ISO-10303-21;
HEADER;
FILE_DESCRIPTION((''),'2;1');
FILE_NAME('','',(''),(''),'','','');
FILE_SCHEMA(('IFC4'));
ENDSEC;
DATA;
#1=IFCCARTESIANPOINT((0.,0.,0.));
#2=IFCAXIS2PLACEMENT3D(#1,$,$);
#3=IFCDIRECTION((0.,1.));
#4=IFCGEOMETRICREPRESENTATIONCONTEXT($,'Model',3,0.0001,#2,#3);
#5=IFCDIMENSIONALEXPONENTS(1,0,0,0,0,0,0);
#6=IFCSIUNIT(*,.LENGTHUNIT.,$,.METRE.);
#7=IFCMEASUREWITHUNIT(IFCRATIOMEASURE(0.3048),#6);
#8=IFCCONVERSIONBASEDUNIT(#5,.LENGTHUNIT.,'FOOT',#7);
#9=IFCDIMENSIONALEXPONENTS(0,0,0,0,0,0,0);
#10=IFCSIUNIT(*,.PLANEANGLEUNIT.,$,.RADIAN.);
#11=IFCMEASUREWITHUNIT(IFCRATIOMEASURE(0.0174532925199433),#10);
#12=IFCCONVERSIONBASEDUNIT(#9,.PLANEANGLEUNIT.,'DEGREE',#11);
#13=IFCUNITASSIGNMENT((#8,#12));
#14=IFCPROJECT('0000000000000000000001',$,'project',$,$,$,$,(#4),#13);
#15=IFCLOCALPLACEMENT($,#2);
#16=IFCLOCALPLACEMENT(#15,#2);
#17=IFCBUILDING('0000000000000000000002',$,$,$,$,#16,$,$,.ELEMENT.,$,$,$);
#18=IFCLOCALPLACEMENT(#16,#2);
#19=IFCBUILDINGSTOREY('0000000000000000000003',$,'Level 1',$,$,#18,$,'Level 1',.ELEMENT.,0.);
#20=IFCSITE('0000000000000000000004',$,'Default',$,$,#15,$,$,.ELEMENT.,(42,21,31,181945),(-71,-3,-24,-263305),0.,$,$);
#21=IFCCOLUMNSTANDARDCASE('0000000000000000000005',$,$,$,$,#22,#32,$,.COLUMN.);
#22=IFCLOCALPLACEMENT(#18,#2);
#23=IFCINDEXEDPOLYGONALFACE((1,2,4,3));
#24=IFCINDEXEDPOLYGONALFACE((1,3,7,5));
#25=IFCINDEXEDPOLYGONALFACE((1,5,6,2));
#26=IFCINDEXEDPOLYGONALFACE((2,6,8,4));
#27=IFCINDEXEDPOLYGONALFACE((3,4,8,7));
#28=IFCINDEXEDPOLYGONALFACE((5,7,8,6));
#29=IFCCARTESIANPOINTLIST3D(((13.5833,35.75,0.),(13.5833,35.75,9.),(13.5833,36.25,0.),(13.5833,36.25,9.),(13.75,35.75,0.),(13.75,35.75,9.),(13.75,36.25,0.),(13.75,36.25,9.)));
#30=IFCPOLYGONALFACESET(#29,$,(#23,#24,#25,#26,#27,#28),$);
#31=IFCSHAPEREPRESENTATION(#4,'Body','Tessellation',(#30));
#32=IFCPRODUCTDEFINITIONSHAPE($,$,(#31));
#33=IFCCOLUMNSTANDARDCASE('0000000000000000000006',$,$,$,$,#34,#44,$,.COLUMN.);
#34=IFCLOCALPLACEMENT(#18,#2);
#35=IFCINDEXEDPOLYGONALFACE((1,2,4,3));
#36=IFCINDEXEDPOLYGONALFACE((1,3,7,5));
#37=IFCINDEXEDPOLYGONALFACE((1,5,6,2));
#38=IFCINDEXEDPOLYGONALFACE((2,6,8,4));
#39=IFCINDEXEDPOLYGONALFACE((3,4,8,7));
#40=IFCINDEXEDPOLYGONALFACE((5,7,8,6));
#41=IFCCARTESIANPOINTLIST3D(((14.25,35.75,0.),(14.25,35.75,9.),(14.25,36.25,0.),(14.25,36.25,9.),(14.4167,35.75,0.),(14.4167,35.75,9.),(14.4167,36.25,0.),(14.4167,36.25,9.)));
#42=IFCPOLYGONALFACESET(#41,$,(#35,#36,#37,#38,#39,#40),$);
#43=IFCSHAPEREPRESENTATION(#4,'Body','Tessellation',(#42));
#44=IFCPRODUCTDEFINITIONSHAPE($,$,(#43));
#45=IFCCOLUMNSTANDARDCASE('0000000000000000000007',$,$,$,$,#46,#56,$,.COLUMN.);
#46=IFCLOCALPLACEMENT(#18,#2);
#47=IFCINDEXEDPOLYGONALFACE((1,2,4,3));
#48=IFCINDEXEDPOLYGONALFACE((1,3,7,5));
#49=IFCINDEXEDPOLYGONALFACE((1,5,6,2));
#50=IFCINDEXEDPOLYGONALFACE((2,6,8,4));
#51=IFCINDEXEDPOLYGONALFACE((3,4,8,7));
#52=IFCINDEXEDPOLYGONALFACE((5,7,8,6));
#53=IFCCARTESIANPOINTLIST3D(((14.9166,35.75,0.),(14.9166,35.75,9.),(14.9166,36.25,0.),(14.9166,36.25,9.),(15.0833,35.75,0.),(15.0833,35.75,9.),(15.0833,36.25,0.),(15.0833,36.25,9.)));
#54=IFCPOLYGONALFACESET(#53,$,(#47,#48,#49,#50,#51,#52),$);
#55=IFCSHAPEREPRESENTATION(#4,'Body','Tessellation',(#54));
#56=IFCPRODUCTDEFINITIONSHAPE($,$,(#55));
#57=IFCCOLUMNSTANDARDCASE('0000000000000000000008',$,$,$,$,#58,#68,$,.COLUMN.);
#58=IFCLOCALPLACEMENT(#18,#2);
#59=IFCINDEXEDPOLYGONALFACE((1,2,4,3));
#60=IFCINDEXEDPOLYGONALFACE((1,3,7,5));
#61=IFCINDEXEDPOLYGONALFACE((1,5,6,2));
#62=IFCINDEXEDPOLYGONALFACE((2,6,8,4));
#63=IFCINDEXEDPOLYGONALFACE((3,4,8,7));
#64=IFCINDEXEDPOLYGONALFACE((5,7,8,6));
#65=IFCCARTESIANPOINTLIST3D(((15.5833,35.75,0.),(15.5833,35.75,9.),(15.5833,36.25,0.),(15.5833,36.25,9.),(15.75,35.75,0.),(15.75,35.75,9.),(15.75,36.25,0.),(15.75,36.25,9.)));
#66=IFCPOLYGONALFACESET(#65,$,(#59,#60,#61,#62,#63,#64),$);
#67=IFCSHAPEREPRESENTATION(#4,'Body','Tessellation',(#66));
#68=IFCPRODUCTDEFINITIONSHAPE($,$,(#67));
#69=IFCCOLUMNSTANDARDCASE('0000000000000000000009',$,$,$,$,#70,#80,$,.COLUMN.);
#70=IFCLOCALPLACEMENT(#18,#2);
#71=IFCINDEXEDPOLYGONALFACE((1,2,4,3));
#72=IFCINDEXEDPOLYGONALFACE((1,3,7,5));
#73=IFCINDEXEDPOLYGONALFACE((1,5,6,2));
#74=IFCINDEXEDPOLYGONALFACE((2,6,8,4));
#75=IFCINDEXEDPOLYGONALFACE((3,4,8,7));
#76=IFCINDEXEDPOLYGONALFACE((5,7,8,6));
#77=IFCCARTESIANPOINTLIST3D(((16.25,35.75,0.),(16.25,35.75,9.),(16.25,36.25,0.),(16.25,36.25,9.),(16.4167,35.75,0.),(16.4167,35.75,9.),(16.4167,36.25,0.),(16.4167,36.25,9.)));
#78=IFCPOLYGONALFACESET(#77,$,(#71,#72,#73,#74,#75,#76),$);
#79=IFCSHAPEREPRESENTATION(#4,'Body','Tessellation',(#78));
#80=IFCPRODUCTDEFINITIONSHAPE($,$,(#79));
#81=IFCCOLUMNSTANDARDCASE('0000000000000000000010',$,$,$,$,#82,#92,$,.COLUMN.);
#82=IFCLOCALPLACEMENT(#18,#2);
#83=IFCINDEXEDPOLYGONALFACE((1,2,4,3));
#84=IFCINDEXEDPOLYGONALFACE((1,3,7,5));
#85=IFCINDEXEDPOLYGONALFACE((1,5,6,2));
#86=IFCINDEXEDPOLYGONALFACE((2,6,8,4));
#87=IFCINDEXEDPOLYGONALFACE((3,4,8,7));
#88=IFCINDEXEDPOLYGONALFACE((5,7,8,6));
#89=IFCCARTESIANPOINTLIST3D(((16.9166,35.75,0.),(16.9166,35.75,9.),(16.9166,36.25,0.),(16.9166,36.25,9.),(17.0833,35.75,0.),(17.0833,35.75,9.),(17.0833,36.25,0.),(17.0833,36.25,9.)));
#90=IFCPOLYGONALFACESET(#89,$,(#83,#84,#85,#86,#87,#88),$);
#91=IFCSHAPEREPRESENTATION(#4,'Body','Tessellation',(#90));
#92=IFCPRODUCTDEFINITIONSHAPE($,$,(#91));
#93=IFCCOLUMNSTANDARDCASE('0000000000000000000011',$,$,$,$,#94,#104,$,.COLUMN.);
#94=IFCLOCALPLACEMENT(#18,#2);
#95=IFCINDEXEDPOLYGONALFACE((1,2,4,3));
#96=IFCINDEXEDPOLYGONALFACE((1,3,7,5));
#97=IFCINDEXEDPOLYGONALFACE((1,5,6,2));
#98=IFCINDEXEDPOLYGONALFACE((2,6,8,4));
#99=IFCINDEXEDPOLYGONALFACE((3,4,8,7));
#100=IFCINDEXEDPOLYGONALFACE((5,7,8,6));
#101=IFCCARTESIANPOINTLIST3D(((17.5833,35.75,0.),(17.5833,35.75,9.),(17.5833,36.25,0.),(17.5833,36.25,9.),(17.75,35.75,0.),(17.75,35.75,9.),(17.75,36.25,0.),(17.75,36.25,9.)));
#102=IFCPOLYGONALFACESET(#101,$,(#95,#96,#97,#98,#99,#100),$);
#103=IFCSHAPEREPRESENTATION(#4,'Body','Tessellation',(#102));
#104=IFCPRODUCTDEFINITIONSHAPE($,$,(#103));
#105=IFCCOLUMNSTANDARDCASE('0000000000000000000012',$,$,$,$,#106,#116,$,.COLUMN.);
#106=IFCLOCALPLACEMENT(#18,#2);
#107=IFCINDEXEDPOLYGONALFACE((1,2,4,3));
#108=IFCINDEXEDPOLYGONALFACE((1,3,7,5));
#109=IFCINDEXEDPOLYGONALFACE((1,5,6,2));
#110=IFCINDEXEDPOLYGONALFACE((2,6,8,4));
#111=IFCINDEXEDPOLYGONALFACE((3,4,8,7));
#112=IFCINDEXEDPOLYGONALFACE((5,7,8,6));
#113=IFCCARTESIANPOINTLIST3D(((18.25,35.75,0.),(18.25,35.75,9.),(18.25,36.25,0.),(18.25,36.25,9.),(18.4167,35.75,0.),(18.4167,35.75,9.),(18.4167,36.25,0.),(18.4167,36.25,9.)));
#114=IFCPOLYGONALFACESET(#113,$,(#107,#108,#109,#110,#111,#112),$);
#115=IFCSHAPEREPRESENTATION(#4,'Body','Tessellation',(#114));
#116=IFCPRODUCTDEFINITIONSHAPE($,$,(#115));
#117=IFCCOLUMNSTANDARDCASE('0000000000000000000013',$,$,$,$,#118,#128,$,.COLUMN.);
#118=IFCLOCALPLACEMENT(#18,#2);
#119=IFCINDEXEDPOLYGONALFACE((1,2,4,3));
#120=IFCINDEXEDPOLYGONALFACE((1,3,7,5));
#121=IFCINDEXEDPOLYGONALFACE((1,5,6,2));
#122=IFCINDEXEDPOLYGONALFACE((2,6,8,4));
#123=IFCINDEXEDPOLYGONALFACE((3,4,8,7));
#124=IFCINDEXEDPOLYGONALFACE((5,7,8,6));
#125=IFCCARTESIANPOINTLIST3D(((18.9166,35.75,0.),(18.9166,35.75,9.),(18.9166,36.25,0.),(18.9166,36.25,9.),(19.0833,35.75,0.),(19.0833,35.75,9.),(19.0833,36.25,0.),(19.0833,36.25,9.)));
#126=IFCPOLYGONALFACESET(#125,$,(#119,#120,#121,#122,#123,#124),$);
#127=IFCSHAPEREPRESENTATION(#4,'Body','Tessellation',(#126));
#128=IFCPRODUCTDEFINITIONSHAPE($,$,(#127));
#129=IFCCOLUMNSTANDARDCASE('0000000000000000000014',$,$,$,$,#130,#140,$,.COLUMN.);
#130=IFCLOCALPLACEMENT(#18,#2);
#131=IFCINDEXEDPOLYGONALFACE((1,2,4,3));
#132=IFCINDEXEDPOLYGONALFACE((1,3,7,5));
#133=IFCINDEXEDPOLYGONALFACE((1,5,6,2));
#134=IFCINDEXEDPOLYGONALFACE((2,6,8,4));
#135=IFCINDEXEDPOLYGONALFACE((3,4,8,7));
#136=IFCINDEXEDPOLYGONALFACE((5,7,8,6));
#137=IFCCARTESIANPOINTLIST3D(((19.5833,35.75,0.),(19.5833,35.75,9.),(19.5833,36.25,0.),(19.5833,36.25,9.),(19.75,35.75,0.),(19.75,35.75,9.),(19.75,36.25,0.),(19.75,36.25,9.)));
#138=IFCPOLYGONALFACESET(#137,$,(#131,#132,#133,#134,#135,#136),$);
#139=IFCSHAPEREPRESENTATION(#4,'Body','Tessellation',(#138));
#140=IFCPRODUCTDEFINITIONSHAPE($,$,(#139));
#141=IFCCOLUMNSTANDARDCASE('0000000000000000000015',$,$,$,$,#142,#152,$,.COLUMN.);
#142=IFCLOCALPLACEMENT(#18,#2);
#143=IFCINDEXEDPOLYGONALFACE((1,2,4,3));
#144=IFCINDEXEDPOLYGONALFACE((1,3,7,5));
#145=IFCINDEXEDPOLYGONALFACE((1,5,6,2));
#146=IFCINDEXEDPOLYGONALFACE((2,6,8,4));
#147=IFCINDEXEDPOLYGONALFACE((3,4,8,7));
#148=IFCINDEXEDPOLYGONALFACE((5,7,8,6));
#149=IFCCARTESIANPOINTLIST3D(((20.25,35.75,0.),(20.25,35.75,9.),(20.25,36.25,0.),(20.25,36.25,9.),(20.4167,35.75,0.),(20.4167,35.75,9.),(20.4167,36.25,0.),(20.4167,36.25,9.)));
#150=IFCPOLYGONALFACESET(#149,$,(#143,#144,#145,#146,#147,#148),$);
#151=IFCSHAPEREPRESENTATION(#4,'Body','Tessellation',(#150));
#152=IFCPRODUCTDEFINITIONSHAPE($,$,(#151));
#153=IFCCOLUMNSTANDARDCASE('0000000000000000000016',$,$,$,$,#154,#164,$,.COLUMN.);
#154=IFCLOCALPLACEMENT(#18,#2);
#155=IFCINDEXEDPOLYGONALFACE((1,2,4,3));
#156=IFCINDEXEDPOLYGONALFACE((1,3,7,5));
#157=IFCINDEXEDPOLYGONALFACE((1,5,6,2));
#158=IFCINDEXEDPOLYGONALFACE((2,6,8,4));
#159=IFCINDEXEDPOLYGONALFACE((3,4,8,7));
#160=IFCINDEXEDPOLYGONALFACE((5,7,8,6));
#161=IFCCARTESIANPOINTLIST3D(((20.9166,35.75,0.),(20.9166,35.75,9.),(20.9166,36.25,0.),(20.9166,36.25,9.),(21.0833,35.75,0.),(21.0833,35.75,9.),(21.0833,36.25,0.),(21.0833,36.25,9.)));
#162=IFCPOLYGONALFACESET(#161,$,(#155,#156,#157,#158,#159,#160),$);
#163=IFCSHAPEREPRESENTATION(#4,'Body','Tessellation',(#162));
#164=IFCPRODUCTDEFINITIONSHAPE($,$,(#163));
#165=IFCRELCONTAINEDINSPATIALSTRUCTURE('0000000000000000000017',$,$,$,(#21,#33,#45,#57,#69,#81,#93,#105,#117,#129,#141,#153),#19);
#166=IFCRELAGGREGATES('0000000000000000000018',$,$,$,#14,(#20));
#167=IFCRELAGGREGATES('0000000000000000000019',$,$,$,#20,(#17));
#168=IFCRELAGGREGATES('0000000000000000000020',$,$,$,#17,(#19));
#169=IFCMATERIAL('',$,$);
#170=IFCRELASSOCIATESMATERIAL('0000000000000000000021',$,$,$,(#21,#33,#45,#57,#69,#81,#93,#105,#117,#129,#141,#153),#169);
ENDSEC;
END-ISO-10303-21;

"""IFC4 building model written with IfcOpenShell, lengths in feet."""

from ifc_helpers import new_model, entity, si_unit, converted_unit, direction, frame, origin, place, context, project, spatial, rectangle, extrude, material, element, save


model = new_model("IFC4")

# Units and contexts
model_context = context("Model", 3, precision=0.0001, world=origin(), true_north=direction((0.0, 1.0)))
ifc_project = project(units=[converted_unit("LENGTHUNIT", "FOOT", entity("IfcRatioMeasure", 0.3048), si_unit("LENGTHUNIT", "METRE"), dimensions=[1, 0, 0, 0, 0, 0, 0]), converted_unit("PLANEANGLEUNIT", "DEGREE", entity("IfcRatioMeasure", 0.0174532925199433), si_unit("PLANEANGLEUNIT", "RADIAN"), dimensions=[0, 0, 0, 0, 0, 0, 0])], contexts=[model_context])

# Site, building, storey
site_placement = place(None, origin())
site = spatial("IfcSite", under=ifc_project, at=site_placement, Name="Default", CompositionType="ELEMENT", RefLatitude=(42, 21, 31, 181945), RefLongitude=(-71, -3, -24, -263305), RefElevation=0.0)
building_placement = place(site_placement, origin())
building = spatial("IfcBuilding", under=site, at=building_placement, CompositionType="ELEMENT")
storey_placement = place(building_placement, origin())
storey = spatial("IfcBuildingStorey", under=building, at=storey_placement, Name="Level 1", LongName="Level 1", CompositionType="ELEMENT", Elevation=0.0)

# Columns
ifc_material_1 = material(Name="")
placement = place(storey_placement, frame((0.25, 36.0, 0.0)))
for number, where, z_axis, x_axis in (
    (1, (13.4167, 0.0, 0.0), (0.0, 0.0, 1.0), (1.0, 0.0, 0.0)),
    (2, (14.0833, 0.0, 0.0), (0.0, 0.0, 1.0), (1.0, 0.0, 0.0)),
    (3, (14.75, 0.0, 0.0), (0.0, 0.0, 1.0), (1.0, 0.0, 0.0)),
    (4, (15.4167, 0.0, 0.0), (0.0, 0.0, 1.0), (1.0, 0.0, 0.0)),
    (5, (16.0833, 0.0, 0.0), (0.0, 0.0, 1.0), (1.0, 0.0, 0.0)),
    (6, (16.75, 0.0, 0.0), (0.0, 0.0, 1.0), (1.0, 0.0, 0.0)),
    (7, (17.4167, 0.0, 0.0), (0.0, 0.0, 1.0), (1.0, 0.0, 0.0)),
    (8, (18.0833, 0.0, 0.0), (0.0, 0.0, 1.0), (1.0, 0.0, 0.0)),
    (9, (18.75, 0.0, 0.0), (0.0, 0.0, 1.0), (1.0, 0.0, 0.0)),
    (10, (19.4167, 0.0, 0.0), (0.0, 0.0, 1.0), (1.0, 0.0, 0.0)),
    (11, (20.0833, 0.0, 0.0), (0.0, 0.0, 1.0), (1.0, 0.0, 0.0)),
    (12, (20.75, 0.0, 0.0), (0.0, 0.0, 1.0), (1.0, 0.0, 0.0)),
):
    element("IfcColumnStandardCase", number, at=place(placement, frame(where, z_axis=z_axis, x_axis=x_axis)), inside=storey, material=ifc_material_1, PredefinedType="COLUMN", context=model_context, shape_type="SweptSolid", body=[
        extrude(rectangle(XDim=0.1667, YDim=0.5), origin(), (0.0, 0.0, 1.0), 9.0),
    ])

save(model, "model.ifc")
